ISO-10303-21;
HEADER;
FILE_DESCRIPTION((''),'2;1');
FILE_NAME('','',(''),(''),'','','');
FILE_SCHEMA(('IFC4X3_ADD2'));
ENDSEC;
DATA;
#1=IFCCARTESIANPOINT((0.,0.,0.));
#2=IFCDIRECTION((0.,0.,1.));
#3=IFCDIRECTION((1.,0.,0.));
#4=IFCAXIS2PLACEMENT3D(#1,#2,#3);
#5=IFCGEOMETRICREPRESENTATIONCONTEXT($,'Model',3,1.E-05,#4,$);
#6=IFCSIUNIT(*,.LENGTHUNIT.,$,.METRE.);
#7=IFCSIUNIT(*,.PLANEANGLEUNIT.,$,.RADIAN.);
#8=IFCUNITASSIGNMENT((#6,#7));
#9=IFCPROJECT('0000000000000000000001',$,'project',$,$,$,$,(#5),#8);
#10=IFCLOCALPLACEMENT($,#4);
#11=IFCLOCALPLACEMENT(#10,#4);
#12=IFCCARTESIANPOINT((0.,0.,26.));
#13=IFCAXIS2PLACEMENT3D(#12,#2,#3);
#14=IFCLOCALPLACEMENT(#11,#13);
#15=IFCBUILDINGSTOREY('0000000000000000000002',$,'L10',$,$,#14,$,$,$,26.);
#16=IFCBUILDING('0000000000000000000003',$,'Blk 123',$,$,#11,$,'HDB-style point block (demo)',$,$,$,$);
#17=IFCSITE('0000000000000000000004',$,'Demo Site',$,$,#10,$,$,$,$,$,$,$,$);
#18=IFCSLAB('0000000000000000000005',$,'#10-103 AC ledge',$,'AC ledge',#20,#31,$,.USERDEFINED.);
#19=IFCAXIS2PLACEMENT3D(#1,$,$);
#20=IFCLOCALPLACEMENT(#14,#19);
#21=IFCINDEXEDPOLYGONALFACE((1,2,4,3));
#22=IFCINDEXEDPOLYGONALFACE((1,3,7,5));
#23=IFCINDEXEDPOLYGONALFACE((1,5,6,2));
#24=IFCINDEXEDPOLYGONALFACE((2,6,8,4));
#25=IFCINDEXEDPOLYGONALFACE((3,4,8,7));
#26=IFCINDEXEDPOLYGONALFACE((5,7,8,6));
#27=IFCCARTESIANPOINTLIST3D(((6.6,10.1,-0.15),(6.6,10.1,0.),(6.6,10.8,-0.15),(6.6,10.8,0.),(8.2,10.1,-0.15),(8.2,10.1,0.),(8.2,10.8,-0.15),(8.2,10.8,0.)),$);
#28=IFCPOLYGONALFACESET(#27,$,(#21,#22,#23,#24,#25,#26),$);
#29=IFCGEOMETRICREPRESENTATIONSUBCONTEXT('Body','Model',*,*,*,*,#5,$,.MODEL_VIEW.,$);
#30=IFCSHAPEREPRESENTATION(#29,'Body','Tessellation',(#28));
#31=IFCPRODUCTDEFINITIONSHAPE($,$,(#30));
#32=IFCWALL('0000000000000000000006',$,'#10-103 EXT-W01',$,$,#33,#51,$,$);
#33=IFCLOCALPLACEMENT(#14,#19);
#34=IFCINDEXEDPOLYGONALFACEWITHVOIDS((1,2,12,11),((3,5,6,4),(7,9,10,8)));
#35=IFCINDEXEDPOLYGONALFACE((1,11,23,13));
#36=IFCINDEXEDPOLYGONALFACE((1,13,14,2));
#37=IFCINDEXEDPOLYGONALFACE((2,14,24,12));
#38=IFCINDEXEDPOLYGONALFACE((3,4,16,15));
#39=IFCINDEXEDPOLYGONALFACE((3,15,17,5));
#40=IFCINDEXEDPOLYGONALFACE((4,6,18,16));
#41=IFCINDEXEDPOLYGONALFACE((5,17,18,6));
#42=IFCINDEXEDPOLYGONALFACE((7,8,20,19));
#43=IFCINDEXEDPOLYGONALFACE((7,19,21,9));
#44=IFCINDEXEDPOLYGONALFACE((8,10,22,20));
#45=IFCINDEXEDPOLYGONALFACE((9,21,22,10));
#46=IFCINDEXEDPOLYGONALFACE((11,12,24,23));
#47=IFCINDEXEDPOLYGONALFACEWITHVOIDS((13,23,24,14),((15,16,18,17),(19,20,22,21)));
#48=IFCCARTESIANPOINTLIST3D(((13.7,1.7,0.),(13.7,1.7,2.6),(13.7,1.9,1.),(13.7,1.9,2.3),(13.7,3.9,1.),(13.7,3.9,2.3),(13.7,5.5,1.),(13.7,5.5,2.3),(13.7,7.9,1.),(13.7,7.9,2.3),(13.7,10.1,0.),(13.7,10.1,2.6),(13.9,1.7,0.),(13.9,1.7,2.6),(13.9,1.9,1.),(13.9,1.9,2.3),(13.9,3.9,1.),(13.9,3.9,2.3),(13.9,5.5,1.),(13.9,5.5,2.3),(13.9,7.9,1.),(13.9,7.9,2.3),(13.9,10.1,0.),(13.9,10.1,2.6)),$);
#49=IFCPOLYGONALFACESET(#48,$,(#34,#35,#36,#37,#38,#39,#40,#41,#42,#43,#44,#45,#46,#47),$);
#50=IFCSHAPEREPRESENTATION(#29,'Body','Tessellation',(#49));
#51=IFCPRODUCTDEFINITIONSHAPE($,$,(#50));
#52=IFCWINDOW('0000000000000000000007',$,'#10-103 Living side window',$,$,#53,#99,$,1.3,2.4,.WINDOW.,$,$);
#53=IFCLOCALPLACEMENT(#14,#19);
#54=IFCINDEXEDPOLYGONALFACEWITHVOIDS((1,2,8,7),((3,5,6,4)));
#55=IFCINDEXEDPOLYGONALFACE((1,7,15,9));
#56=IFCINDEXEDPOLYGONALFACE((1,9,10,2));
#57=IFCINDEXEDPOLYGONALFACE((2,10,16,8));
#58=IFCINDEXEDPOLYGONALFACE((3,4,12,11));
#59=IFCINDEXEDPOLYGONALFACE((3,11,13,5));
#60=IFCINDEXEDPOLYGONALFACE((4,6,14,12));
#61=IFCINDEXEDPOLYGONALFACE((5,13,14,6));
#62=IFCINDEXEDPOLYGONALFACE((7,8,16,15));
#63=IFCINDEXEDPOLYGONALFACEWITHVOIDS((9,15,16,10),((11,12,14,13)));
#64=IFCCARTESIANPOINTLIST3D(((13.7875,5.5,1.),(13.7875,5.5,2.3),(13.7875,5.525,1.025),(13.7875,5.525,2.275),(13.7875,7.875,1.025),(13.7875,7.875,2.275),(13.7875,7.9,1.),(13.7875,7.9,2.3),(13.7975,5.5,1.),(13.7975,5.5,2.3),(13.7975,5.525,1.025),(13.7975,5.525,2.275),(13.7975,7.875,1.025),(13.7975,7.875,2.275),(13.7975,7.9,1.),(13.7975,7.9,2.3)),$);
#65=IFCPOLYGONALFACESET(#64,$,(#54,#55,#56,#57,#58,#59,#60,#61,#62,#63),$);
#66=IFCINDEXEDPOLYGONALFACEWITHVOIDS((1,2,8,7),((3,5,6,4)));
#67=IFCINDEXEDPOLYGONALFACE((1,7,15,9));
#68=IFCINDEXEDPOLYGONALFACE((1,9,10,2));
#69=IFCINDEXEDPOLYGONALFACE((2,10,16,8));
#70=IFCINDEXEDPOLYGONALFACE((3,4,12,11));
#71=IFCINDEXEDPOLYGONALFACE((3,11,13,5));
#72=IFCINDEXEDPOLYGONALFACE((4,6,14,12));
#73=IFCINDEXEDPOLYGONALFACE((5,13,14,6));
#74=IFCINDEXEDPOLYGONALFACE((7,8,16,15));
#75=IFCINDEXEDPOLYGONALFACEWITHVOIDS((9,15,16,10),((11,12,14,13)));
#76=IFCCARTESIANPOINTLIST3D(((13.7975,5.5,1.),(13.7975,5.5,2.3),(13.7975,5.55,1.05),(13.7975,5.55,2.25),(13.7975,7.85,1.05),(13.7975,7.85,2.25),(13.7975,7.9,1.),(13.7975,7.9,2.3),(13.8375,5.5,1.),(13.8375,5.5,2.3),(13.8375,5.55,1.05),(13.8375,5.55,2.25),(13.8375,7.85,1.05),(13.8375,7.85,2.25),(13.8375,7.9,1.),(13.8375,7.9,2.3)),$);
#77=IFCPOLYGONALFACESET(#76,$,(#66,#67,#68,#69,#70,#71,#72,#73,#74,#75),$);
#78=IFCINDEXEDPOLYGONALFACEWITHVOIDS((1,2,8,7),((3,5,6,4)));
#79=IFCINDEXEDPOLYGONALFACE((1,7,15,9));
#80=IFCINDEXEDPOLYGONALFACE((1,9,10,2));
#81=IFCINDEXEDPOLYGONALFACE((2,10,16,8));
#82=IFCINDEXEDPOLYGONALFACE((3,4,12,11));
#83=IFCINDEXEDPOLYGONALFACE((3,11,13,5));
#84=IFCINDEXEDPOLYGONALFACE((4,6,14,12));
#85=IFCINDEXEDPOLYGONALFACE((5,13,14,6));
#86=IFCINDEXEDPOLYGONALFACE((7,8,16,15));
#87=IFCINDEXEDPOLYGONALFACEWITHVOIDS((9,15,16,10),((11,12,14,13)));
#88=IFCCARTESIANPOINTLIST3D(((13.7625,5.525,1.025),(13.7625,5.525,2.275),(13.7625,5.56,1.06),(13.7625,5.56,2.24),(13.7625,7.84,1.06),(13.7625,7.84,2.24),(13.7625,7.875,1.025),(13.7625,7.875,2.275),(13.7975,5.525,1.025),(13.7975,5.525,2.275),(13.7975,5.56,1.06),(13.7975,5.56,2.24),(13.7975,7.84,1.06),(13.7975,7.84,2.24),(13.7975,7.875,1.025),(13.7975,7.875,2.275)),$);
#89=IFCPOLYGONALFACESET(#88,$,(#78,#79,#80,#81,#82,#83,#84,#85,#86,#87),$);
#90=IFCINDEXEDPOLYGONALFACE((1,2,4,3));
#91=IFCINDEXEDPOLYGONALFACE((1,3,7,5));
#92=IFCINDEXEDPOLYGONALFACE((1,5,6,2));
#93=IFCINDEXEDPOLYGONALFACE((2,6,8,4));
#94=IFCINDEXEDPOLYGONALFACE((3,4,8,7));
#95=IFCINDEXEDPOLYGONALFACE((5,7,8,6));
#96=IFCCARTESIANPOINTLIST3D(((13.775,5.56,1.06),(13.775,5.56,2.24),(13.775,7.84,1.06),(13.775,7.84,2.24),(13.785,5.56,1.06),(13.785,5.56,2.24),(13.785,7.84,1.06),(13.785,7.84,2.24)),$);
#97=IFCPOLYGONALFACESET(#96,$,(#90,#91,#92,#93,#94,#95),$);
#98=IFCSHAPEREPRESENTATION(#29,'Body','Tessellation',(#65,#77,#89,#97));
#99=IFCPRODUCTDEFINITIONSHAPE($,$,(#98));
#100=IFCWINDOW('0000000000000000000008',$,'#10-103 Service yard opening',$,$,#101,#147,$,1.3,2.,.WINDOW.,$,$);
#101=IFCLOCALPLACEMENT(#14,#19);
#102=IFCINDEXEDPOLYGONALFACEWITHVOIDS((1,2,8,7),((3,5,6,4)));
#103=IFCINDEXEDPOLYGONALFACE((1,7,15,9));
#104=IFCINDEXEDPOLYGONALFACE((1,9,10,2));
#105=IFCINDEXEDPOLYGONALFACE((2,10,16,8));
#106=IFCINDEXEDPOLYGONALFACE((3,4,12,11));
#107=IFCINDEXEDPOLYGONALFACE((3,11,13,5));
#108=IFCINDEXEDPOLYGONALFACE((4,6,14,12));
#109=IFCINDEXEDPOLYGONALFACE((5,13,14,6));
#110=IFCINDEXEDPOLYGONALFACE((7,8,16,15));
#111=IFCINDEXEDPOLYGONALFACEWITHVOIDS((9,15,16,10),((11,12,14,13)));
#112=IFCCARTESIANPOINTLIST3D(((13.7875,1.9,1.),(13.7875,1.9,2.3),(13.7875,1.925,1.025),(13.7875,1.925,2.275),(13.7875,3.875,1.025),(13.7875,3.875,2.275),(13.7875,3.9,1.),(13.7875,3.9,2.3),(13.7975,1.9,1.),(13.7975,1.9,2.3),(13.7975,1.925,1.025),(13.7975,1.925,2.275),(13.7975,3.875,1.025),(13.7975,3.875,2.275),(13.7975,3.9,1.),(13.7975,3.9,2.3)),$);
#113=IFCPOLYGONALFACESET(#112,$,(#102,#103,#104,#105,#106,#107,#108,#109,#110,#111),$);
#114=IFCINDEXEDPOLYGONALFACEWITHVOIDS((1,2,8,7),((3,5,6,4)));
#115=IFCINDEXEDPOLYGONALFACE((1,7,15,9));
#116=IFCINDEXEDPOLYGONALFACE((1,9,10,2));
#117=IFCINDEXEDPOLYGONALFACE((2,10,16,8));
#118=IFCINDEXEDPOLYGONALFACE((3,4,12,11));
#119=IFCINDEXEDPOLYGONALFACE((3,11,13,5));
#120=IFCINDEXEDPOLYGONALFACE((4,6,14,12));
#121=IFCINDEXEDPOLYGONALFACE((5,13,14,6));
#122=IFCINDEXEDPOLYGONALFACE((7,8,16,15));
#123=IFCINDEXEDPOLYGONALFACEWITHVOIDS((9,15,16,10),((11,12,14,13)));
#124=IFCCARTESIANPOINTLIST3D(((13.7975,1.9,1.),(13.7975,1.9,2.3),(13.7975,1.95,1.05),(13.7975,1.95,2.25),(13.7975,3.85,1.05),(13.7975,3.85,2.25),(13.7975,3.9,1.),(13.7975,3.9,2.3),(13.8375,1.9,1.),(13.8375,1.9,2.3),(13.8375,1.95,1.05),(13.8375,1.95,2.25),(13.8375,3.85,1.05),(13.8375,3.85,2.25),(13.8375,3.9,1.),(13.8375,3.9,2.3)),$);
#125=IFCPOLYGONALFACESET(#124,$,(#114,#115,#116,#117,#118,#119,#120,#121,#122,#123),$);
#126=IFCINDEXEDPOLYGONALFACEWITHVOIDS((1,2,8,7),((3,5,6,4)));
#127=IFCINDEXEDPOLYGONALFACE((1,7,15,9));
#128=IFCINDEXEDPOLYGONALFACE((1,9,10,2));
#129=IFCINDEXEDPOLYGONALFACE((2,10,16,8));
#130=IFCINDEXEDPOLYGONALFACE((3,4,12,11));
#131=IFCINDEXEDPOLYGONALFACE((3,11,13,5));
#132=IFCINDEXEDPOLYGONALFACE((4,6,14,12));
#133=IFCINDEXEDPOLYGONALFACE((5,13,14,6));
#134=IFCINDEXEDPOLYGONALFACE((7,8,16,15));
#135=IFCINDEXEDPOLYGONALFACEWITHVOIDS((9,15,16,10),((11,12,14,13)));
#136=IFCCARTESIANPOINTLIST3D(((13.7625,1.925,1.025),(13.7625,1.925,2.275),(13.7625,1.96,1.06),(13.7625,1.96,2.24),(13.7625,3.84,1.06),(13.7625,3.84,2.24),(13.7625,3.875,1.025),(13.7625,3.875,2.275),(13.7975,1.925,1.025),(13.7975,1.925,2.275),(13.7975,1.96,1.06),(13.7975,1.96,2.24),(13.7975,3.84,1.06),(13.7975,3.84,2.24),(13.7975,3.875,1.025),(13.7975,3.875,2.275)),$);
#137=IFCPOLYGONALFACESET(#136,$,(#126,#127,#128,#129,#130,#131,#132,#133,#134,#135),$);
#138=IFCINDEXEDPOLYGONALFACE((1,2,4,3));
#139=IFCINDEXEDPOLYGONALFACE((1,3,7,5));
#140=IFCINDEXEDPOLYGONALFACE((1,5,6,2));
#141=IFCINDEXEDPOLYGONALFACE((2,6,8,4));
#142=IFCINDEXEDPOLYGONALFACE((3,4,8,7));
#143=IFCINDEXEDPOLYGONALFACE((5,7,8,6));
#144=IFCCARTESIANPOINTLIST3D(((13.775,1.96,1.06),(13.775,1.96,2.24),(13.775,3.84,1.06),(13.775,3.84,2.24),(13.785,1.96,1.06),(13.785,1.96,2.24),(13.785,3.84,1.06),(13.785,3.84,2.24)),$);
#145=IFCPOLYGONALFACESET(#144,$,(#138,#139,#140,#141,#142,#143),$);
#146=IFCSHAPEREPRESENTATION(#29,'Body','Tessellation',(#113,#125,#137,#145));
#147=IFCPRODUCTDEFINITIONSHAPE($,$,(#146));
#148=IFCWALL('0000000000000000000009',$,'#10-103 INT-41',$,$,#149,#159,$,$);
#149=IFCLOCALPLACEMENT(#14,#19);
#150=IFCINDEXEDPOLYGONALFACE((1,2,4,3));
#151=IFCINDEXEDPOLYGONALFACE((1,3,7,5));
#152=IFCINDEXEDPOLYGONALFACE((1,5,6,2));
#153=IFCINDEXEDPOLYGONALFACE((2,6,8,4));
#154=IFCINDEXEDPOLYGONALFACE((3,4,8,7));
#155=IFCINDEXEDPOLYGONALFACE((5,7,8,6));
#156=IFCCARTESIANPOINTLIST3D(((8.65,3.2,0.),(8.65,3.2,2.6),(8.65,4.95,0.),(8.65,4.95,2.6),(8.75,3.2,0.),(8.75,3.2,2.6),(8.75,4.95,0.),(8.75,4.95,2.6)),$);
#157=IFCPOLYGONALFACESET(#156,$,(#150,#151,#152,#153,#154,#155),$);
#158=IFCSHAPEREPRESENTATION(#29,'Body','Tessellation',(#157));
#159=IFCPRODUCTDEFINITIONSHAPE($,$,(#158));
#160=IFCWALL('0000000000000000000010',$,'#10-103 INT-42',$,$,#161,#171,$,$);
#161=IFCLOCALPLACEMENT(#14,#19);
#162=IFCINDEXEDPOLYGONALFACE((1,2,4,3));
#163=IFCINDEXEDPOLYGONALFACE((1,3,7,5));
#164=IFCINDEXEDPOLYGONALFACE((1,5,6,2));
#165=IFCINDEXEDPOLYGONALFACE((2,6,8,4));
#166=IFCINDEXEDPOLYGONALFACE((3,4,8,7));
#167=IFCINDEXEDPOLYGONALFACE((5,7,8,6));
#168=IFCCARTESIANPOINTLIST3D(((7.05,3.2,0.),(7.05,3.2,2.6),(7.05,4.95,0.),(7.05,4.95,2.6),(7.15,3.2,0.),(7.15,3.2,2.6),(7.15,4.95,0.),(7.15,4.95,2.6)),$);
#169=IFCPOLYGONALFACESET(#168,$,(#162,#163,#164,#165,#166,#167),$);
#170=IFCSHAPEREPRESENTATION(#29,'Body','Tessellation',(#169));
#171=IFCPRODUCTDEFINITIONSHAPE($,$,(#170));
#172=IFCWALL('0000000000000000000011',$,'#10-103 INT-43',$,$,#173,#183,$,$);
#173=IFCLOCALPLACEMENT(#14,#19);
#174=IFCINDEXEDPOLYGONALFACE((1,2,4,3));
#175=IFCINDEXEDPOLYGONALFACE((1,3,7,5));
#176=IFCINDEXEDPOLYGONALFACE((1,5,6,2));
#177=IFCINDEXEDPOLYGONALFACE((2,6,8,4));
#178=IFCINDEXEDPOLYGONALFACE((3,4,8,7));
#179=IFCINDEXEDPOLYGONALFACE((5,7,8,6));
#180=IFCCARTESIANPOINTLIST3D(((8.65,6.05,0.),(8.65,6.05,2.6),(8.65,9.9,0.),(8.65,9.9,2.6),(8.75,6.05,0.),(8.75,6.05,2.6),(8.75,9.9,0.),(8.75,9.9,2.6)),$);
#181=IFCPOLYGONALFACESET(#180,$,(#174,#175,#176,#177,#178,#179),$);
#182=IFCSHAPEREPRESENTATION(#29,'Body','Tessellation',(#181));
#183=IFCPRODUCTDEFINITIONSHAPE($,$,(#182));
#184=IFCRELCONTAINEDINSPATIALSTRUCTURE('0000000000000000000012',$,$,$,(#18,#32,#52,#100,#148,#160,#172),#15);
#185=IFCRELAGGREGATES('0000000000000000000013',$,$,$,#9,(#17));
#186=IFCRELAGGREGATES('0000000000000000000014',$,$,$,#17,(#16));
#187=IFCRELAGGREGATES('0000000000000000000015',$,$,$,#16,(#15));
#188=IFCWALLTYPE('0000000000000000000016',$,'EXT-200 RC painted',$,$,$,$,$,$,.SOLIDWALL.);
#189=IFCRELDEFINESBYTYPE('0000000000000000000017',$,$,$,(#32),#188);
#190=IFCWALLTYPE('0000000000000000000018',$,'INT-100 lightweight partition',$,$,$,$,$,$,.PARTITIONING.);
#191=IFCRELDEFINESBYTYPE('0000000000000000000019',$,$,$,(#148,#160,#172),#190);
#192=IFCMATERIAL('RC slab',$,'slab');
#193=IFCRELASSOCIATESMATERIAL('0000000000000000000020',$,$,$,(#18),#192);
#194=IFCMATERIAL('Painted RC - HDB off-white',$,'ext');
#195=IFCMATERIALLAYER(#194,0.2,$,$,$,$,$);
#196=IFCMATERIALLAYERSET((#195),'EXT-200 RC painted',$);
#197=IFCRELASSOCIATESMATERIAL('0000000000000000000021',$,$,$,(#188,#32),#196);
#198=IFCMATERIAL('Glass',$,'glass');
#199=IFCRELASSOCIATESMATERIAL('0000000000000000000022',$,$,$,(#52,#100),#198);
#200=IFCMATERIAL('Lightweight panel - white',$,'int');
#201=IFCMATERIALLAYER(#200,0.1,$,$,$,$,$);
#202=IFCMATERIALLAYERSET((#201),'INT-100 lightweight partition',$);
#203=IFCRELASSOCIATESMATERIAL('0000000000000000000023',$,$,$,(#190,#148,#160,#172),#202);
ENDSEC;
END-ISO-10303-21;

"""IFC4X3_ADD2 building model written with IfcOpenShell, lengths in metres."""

from ifc_helpers import new_model, si_unit, frame, origin, origin_with_axes, place, context, subcontext, project, spatial, polyline, line, indexed_curve, outline, extrude, material, layer, layer_set, layer_usage, type_object, element, fill, save


model = new_model("IFC4X3_ADD2")

# Units and contexts
model_context = context("Model", 3, precision=1e-05, world=origin_with_axes())
body_context = subcontext(model_context, "Body", "Model", "MODEL_VIEW")
ifc_project = project(units=[si_unit("LENGTHUNIT", "METRE"), si_unit("PLANEANGLEUNIT", "RADIAN")], contexts=[model_context])

# Site, building, storey
site_placement = place(None, origin_with_axes())
site = spatial("IfcSite", under=ifc_project, at=site_placement, Name="Demo Site")
building_placement = place(site_placement, origin_with_axes())
building = spatial("IfcBuilding", under=site, at=building_placement, Name="Blk 123", LongName="HDB-style point block (demo)")
storey_placement = place(building_placement, frame((0.0, 0.0, 26.0), z_axis=(0.0, 0.0, 1.0), x_axis=(1.0, 0.0, 0.0)))
storey = spatial("IfcBuildingStorey", under=building, at=storey_placement, Name="L10", Elevation=26.0)

# Slab
ifc_material_1 = material(Name="RC slab", Category="slab")
slab_placement = place(storey_placement, frame((7.4, 10.45, -0.15), z_axis=(0.0, 0.0, 1.0), x_axis=(1.0, 0.0, 0.0)))
element("IfcSlab", 1, at=slab_placement, inside=storey, material=ifc_material_1, Name="#10-103 AC ledge", ObjectType="AC ledge", PredefinedType="USERDEFINED", context=body_context, shape_type="SweptSolid", body=[
    extrude(outline(polyline([(0.8, -0.35), (0.8, 0.35), (-0.8, 0.35), (-0.8, -0.35), (0.8, -0.35)])), origin(), (0.0, 0.0, 1.0), 0.15),
])

# Wall, openings, windows
ifc_material_2 = material(Name="Painted RC - HDB off-white", Category="ext")
ifc_layer_1 = layer(ifc_material_2, 0.2)
ifc_layer_set_1 = layer_set([ifc_layer_1], Name="EXT-200 RC painted")
ifc_layer_usage_1 = layer_usage(ifc_layer_set_1, "AXIS2", "POSITIVE", 0.0)
wall_type_1 = type_object("IfcWallType", Name="EXT-200 RC painted", PredefinedType="SOLIDWALL", material=ifc_layer_set_1)
wall_1_placement = place(storey_placement, frame((13.9, 1.7, 0.0), z_axis=(0.0, 0.0, 1.0), x_axis=(0.0, 1.0, 0.0)))
wall_1 = element("IfcWall", 2, at=wall_1_placement, inside=storey, type_object=wall_type_1, material=ifc_layer_usage_1, Name="#10-103 EXT-W01", context=body_context, shape_type="SweptSolid", body=[
    extrude(outline(indexed_curve([(0.0, 0.0), (0.0, 0.2), (8.4, 0.2), (8.4, 0.0), (0.0, 0.0)], self_intersect=False)), origin_with_axes(), (0.0, 0.0, 1.0), 2.6),
])
opening_1_placement = place(wall_1_placement, frame((3.8, -0.1, 1.0), z_axis=(0.0, 0.0, 1.0), x_axis=(1.0, 0.0, 0.0)))
opening_1 = element("IfcOpeningElement", 3, at=opening_1_placement, cuts=wall_1, context=body_context, shape_type="SweptSolid", body=[
    extrude(outline(indexed_curve([(0.0, 0.0), (0.0, 0.4), (2.4, 0.4), (2.4, 0.0), (0.0, 0.0)], self_intersect=False)), origin_with_axes(), (0.0, 0.0, 1.0), 1.3),
])
opening_2_placement = place(wall_1_placement, frame((0.2, -0.1, 1.0), z_axis=(0.0, 0.0, 1.0), x_axis=(1.0, 0.0, 0.0)))
opening_2 = element("IfcOpeningElement", 4, at=opening_2_placement, cuts=wall_1, context=body_context, shape_type="SweptSolid", body=[
    extrude(outline(indexed_curve([(0.0, 0.0), (0.0, 0.4), (2.0, 0.4), (2.0, 0.0), (0.0, 0.0)], self_intersect=False)), origin_with_axes(), (0.0, 0.0, 1.0), 1.3),
])
ifc_material_3 = material(Name="Glass", Category="glass")
window_1_placement = place(opening_1_placement, frame((0.0, 0.1125, 0.0), z_axis=(0.0, 0.0, 1.0), x_axis=(1.0, 0.0, 0.0)))
window_1 = element("IfcWindow", 5, at=window_1_placement, inside=storey, material=ifc_material_3, Name="#10-103 Living side window", OverallHeight=1.3, OverallWidth=2.4, PredefinedType="WINDOW", context=body_context, shape_type="SweptSolid", body=[
    extrude(outline(indexed_curve([(0.0, 0.0), (2.4, 0.0), (2.4, 1.3), (0.0, 1.3)], segments=[line(1, 2, 3, 4, 1)]), holes=[indexed_curve([(0.025, 0.025), (2.375, 0.025), (2.375, 1.275), (0.025, 1.275)], segments=[line(1, 2, 3, 4, 1)])]), frame((0.0, 0.09, 0.0), z_axis=(0.0, -1.0, 0.0), x_axis=(1.0, 0.0, 0.0)), (0.0, 0.0, -1.0), 0.01),
    extrude(outline(indexed_curve([(0.0, 0.0), (2.4, 0.0), (2.4, 1.3), (0.0, 1.3)], segments=[line(1, 2, 3, 4, 1)]), holes=[indexed_curve([(0.05, 0.05), (2.35, 0.05), (2.35, 1.25), (0.05, 1.25)], segments=[line(1, 2, 3, 4, 1)])]), frame((0.0, 0.05, 0.0), z_axis=(0.0, -1.0, 0.0), x_axis=(1.0, 0.0, 0.0)), (0.0, 0.0, -1.0), 0.04),
    extrude(outline(indexed_curve([(0.0, 0.0), (2.35, 0.0), (2.35, 1.25), (0.0, 1.25)], segments=[line(1, 2, 3, 4, 1)]), holes=[indexed_curve([(0.035, 0.035), (2.315, 0.035), (2.315, 1.215), (0.035, 1.215)], segments=[line(1, 2, 3, 4, 1)])]), frame((0.025, 0.09, 0.025), z_axis=(0.0, -1.0, 0.0), x_axis=(1.0, 0.0, 0.0)), (0.0, 0.0, -1.0), 0.035),
    extrude(outline(indexed_curve([(0.035, 0.035), (2.315, 0.035), (2.315, 1.215), (0.035, 1.215)], segments=[line(1, 2, 3, 4, 1)])), frame((0.025, 0.1025, 0.025), z_axis=(0.0, -1.0, 0.0), x_axis=(1.0, 0.0, 0.0)), (0.0, 0.0, -1.0), 0.01),
])
fill(opening_1, window_1)
window_2_placement = place(opening_2_placement, frame((0.0, 0.1125, 0.0), z_axis=(0.0, 0.0, 1.0), x_axis=(1.0, 0.0, 0.0)))
window_2 = element("IfcWindow", 6, at=window_2_placement, inside=storey, material=ifc_material_3, Name="#10-103 Service yard opening", OverallHeight=1.3, OverallWidth=2.0, PredefinedType="WINDOW", context=body_context, shape_type="SweptSolid", body=[
    extrude(outline(indexed_curve([(0.0, 0.0), (2.0, 0.0), (2.0, 1.3), (0.0, 1.3)], segments=[line(1, 2, 3, 4, 1)]), holes=[indexed_curve([(0.025, 0.025), (1.975, 0.025), (1.975, 1.275), (0.025, 1.275)], segments=[line(1, 2, 3, 4, 1)])]), frame((0.0, 0.09, 0.0), z_axis=(0.0, -1.0, 0.0), x_axis=(1.0, 0.0, 0.0)), (0.0, 0.0, -1.0), 0.01),
    extrude(outline(indexed_curve([(0.0, 0.0), (2.0, 0.0), (2.0, 1.3), (0.0, 1.3)], segments=[line(1, 2, 3, 4, 1)]), holes=[indexed_curve([(0.05, 0.05), (1.95, 0.05), (1.95, 1.25), (0.05, 1.25)], segments=[line(1, 2, 3, 4, 1)])]), frame((0.0, 0.05, 0.0), z_axis=(0.0, -1.0, 0.0), x_axis=(1.0, 0.0, 0.0)), (0.0, 0.0, -1.0), 0.04),
    extrude(outline(indexed_curve([(0.0, 0.0), (1.95, 0.0), (1.95, 1.25), (0.0, 1.25)], segments=[line(1, 2, 3, 4, 1)]), holes=[indexed_curve([(0.035, 0.035), (1.915, 0.035), (1.915, 1.215), (0.035, 1.215)], segments=[line(1, 2, 3, 4, 1)])]), frame((0.025, 0.09, 0.025), z_axis=(0.0, -1.0, 0.0), x_axis=(1.0, 0.0, 0.0)), (0.0, 0.0, -1.0), 0.035),
    extrude(outline(indexed_curve([(0.035, 0.035), (1.915, 0.035), (1.915, 1.215), (0.035, 1.215)], segments=[line(1, 2, 3, 4, 1)])), frame((0.025, 0.1025, 0.025), z_axis=(0.0, -1.0, 0.0), x_axis=(1.0, 0.0, 0.0)), (0.0, 0.0, -1.0), 0.01),
])
fill(opening_2, window_2)

# Walls
ifc_material_4 = material(Name="Lightweight panel - white", Category="int")
ifc_layer_2 = layer(ifc_material_4, 0.1)
ifc_layer_set_2 = layer_set([ifc_layer_2], Name="INT-100 lightweight partition")
ifc_layer_usage_2 = layer_usage(ifc_layer_set_2, "AXIS2", "POSITIVE", -0.05)
wall_type_2 = type_object("IfcWallType", Name="INT-100 lightweight partition", PredefinedType="PARTITIONING", material=ifc_layer_set_2)
for number, where, z_axis, x_axis, name in (
    (7, (8.7, 3.2, 0.0), (0.0, 0.0, 1.0), (0.0, 1.0, 0.0), "#10-103 INT-41"),
    (8, (7.1, 3.2, 0.0), (0.0, 0.0, 1.0), (0.0, 1.0, 0.0), "#10-103 INT-42"),
):
    element("IfcWall", number, at=place(storey_placement, frame(where, z_axis=z_axis, x_axis=x_axis)), inside=storey, type_object=wall_type_2, material=ifc_layer_usage_2, Name=name, context=body_context, shape_type="SweptSolid", body=[
        extrude(outline(indexed_curve([(0.0, 0.0), (0.0, 0.1), (1.75, 0.1), (1.75, 0.0), (0.0, 0.0)], self_intersect=False)), frame((0.0, -0.05, 0.0), z_axis=(0.0, 0.0, 1.0), x_axis=(1.0, 0.0, 0.0)), (0.0, 0.0, 1.0), 2.6),
    ])
wall_2_placement = place(storey_placement, frame((8.7, 6.05, 0.0), z_axis=(0.0, 0.0, 1.0), x_axis=(0.0, 1.0, 0.0)))
element("IfcWall", 9, at=wall_2_placement, inside=storey, type_object=wall_type_2, material=ifc_layer_usage_2, Name="#10-103 INT-43", context=body_context, shape_type="SweptSolid", body=[
    extrude(outline(indexed_curve([(0.0, 0.0), (0.0, 0.1), (3.85, 0.1), (3.85, 0.0), (0.0, 0.0)], self_intersect=False)), frame((0.0, -0.05, 0.0), z_axis=(0.0, 0.0, 1.0), x_axis=(1.0, 0.0, 0.0)), (0.0, 0.0, 1.0), 2.6),
])

save(model, "model.ifc")
